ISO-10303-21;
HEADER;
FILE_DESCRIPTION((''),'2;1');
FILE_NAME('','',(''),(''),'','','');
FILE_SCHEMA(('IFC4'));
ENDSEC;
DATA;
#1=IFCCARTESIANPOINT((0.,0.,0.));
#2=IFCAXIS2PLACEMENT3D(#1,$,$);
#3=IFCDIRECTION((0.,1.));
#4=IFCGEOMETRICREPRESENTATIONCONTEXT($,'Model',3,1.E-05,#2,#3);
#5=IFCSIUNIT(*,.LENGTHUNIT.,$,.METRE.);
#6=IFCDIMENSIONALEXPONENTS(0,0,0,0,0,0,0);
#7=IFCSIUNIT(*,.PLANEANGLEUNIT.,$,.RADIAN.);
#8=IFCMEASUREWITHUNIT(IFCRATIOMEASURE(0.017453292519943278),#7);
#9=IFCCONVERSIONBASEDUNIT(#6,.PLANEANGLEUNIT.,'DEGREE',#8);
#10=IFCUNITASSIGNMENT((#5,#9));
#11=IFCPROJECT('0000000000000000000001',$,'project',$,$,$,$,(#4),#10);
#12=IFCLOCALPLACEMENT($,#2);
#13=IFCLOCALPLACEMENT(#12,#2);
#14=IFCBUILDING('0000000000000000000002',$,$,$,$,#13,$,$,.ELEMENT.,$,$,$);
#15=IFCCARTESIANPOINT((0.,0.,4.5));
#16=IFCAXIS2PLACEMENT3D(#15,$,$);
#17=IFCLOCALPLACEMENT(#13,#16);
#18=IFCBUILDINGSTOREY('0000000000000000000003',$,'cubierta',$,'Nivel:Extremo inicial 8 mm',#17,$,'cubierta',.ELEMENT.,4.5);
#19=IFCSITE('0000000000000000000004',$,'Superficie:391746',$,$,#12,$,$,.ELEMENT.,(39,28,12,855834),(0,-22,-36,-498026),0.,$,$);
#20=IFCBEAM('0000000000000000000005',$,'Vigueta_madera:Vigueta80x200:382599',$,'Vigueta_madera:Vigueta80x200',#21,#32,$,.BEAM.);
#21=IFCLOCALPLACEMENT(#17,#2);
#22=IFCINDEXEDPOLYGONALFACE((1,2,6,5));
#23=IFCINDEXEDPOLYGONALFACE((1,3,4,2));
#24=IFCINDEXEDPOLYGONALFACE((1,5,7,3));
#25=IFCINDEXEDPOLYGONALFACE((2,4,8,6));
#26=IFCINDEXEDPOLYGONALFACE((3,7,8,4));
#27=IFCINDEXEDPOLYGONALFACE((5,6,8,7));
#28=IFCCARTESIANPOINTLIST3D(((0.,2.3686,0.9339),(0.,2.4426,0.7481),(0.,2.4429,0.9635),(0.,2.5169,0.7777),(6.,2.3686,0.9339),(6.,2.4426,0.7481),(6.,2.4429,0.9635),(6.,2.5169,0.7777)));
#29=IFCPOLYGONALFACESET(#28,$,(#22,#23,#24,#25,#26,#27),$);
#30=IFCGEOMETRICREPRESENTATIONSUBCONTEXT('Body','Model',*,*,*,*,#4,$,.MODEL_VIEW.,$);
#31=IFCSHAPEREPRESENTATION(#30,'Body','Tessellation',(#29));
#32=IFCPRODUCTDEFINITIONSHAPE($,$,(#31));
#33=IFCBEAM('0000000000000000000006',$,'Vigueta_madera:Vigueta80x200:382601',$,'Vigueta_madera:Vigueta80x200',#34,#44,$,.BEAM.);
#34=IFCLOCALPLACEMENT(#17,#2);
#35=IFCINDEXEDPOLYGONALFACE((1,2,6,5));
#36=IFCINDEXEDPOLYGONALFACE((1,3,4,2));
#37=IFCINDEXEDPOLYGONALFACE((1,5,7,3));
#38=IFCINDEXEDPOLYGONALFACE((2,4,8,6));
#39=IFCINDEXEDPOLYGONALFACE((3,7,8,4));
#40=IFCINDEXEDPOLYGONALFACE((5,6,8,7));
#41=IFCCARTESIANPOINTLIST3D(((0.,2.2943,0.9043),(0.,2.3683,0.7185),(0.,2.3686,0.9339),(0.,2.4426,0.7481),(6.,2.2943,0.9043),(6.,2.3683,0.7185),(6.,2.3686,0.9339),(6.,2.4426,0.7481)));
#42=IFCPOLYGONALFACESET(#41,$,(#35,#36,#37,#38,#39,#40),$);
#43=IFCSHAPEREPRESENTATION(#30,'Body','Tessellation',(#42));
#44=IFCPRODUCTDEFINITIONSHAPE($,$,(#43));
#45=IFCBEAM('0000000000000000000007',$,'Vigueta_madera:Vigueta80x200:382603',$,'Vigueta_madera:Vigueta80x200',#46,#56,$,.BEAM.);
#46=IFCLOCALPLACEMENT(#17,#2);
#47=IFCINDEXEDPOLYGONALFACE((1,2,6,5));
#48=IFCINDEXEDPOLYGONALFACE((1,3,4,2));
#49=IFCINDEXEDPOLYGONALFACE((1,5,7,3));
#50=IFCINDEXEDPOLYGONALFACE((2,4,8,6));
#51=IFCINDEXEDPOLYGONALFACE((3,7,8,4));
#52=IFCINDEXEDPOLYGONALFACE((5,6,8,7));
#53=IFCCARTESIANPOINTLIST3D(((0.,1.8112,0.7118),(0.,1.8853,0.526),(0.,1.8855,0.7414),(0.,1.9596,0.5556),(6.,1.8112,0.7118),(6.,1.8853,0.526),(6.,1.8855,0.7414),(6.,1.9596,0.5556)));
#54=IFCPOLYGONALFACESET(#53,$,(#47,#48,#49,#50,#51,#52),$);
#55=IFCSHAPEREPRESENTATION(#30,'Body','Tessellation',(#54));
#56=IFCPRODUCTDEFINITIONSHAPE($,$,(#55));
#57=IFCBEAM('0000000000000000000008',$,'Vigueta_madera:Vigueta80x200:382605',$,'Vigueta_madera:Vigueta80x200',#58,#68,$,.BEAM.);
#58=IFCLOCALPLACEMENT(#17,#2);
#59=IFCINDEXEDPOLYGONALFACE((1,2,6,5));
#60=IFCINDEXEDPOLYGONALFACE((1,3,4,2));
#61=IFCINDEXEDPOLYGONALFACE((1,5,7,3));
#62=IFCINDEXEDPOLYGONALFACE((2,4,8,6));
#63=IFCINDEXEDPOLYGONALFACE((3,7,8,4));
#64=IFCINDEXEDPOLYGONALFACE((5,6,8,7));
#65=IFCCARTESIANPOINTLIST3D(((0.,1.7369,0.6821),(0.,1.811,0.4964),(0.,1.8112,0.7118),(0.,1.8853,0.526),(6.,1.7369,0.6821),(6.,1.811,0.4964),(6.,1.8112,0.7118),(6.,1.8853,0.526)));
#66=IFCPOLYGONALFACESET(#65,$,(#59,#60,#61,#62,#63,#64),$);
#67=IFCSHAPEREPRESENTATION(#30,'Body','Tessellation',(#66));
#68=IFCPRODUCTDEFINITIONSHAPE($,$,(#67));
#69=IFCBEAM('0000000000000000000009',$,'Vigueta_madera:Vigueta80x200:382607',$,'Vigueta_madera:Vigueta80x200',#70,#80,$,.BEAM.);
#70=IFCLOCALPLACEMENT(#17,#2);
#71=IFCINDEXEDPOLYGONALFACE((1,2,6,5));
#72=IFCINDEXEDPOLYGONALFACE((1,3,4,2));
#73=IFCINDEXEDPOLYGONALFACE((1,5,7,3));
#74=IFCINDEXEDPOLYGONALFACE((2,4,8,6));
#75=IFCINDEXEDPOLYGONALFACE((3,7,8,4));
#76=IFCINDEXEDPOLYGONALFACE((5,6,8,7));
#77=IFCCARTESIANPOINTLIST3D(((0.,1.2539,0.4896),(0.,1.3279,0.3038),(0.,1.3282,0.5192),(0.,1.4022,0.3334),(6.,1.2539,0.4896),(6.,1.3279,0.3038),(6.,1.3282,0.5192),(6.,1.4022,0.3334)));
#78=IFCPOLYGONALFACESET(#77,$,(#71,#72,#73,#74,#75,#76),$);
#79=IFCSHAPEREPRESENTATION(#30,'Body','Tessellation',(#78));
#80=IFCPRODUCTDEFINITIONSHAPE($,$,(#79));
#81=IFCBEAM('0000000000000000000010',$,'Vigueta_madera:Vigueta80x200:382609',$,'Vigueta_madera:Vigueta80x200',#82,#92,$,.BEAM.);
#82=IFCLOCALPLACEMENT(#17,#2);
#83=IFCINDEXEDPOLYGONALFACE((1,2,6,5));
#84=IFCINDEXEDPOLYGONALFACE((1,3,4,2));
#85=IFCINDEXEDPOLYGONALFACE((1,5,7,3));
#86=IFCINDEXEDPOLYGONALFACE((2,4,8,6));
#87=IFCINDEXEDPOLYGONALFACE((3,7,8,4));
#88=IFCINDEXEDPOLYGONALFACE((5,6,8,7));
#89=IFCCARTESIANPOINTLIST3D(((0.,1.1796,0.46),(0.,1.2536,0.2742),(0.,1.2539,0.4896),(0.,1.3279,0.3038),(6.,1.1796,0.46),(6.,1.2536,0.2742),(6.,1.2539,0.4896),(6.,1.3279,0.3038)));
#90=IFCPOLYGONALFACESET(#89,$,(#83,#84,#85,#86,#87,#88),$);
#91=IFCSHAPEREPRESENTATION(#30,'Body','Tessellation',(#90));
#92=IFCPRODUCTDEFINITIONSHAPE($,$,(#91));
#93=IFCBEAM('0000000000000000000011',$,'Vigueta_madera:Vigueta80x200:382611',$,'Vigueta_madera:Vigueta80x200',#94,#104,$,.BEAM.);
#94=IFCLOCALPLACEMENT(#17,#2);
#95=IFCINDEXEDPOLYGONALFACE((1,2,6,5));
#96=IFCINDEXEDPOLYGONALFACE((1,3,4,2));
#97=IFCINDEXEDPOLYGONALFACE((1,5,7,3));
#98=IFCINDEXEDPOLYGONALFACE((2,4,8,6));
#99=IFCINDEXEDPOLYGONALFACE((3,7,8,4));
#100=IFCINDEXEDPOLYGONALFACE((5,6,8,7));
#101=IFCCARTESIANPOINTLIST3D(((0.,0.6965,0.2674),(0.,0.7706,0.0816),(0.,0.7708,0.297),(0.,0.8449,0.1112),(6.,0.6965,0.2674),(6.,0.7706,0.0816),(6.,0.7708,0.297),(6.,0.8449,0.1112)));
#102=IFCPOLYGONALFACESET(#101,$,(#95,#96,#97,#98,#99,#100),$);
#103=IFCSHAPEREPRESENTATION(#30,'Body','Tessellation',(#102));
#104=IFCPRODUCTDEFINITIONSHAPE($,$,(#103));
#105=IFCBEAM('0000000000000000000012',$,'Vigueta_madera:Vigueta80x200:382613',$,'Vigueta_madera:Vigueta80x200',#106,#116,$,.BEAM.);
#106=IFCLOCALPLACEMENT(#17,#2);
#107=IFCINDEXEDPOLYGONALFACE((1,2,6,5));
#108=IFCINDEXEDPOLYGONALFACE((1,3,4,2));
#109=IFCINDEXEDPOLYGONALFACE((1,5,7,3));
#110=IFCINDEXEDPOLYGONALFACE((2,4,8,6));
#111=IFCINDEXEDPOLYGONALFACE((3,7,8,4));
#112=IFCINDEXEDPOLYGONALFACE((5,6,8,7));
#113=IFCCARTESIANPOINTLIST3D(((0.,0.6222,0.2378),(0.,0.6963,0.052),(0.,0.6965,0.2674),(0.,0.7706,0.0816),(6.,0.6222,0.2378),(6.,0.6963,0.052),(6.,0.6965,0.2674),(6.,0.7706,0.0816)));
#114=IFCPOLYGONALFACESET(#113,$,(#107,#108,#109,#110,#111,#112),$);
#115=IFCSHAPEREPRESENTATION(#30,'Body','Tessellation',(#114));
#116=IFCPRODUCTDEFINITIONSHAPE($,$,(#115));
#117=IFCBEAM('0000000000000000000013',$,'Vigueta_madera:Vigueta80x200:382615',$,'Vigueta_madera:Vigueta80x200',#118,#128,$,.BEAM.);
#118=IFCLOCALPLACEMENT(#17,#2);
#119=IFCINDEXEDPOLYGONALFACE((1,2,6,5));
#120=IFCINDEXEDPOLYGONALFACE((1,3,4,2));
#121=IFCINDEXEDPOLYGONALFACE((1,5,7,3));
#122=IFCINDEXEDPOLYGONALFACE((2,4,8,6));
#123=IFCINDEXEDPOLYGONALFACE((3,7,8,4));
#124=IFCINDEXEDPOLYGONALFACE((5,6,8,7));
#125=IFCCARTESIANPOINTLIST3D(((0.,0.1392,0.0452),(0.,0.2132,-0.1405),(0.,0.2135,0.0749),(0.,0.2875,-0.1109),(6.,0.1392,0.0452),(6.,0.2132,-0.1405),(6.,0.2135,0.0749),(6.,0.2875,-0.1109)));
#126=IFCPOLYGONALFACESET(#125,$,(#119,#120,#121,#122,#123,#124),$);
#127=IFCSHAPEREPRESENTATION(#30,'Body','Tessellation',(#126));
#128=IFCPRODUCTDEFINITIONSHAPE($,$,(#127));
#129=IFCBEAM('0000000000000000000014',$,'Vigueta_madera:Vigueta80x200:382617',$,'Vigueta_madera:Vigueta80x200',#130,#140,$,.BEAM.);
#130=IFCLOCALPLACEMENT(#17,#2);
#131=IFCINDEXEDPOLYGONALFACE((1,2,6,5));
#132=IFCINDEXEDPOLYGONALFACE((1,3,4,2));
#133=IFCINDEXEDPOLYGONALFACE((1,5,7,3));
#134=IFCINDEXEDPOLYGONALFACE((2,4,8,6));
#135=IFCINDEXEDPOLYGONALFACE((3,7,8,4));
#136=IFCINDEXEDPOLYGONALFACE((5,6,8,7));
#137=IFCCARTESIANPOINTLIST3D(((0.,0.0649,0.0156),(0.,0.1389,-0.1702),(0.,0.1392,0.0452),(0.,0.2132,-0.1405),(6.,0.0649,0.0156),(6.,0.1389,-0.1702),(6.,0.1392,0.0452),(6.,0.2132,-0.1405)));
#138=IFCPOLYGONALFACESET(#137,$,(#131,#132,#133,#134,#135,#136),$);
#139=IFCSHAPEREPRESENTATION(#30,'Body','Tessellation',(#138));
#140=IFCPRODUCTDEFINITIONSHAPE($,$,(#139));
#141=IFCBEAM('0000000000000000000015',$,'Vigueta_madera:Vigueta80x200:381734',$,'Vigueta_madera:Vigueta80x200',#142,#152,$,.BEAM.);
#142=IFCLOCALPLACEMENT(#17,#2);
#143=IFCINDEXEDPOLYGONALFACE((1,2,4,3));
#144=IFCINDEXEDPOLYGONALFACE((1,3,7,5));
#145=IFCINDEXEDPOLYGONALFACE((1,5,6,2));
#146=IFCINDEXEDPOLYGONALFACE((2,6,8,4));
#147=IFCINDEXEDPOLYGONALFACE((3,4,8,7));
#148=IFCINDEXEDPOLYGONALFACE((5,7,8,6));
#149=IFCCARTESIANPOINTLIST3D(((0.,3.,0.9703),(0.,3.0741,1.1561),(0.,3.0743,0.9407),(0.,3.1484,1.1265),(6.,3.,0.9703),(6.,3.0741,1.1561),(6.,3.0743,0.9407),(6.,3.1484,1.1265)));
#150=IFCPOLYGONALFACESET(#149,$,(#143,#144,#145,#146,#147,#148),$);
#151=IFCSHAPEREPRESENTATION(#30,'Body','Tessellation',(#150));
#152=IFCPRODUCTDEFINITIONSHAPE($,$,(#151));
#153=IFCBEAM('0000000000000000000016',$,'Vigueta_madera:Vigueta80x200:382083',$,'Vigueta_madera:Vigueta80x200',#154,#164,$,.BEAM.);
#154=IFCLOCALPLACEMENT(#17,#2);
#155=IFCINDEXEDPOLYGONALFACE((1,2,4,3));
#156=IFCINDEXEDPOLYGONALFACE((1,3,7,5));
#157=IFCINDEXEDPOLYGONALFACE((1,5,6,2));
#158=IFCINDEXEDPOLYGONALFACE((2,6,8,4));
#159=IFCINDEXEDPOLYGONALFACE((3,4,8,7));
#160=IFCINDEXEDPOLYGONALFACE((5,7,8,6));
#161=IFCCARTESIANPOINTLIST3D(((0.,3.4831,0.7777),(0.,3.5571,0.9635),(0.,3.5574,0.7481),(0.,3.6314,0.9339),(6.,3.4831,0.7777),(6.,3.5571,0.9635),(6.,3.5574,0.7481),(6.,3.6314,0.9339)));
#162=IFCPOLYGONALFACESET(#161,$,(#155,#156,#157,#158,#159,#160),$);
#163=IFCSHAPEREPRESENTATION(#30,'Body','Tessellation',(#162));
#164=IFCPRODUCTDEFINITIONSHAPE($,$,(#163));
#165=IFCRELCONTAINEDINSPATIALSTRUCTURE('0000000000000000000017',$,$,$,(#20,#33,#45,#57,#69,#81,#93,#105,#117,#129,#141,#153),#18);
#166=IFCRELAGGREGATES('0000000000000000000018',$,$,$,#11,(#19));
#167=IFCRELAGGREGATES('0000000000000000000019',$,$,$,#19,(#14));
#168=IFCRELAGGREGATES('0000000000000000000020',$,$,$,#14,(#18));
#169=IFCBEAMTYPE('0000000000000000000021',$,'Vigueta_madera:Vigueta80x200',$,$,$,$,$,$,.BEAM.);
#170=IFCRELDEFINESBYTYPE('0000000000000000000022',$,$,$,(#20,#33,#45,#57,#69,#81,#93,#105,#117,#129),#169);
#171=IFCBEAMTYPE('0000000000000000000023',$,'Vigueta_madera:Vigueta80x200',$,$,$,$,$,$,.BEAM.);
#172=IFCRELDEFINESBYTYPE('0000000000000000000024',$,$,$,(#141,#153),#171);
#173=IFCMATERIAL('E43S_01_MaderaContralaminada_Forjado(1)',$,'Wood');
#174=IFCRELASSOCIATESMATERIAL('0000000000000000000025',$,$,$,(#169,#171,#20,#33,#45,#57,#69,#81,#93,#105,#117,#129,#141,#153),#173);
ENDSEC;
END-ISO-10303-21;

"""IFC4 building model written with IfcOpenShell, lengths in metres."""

from ifc_helpers import new_model, entity, si_unit, converted_unit, direction, frame, frame_2d, origin, place, context, subcontext, project, spatial, polyline, segment, composite_curve, rectangle, outline, extrude, source, transform, mapped, material, material_profile, profile_set, profile_usage, type_object, type_shapes, element, save


model = new_model("IFC4")

# Units and contexts
model_context = context("Model", 3, precision=1e-05, world=origin(), true_north=direction((0.0, 1.0)))
body_context = subcontext(model_context, "Body", "Model", "MODEL_VIEW")
ifc_project = project(units=[si_unit("LENGTHUNIT", "METRE"), converted_unit("PLANEANGLEUNIT", "DEGREE", entity("IfcRatioMeasure", 0.017453292519943278), si_unit("PLANEANGLEUNIT", "RADIAN"), dimensions=[0, 0, 0, 0, 0, 0, 0])], contexts=[model_context])

# Site, building, storey
site_placement = place(None, origin())
site = spatial("IfcSite", under=ifc_project, at=site_placement, Name="Superficie:391746", CompositionType="ELEMENT", RefLatitude=(39, 28, 12, 855834), RefLongitude=(0, -22, -36, -498026), RefElevation=0.0)
building_placement = place(site_placement, origin())
building = spatial("IfcBuilding", under=site, at=building_placement, CompositionType="ELEMENT")
storey_placement = place(building_placement, frame((0.0, 0.0, 4.5)))
storey = spatial("IfcBuildingStorey", under=building, at=storey_placement, Name="cubierta", ObjectType="Nivel:Extremo inicial 8 mm", LongName="cubierta", CompositionType="ELEMENT", Elevation=4.5)

# Beams
ifc_material = material(Name="E43S_01_MaderaContralaminada_Forjado(1)", Category="Wood")
ifc_material_profile_1 = material_profile(ifc_material, outline(composite_curve([segment(polyline([(0.04, 0.1, 0.0), (0.04, -0.1, 0.0)]), True, "CONTINUOUS"), segment(polyline([(0.04, -0.1, 0.0), (-0.04, -0.1, 0.0)]), True, "CONTINUOUS"), segment(polyline([(-0.04, -0.1, 0.0), (-0.04, 0.1, 0.0)]), True, "CONTINUOUS"), segment(polyline([(-0.04, 0.1, 0.0), (0.04, 0.1, 0.0)]), True, "CONTINUOUS")], self_intersect=False), kind="CURVE"), Name="Vigueta80x200")
ifc_material_profile_2 = material_profile(ifc_material, outline(composite_curve([segment(polyline([(-3.0, 0.04, 0.1), (-3.0, 0.04, -0.1)]), True, "CONTINUOUS"), segment(polyline([(-3.0, 0.04, -0.1), (-3.0, -0.04, -0.1)]), True, "CONTINUOUS"), segment(polyline([(-3.0, -0.04, -0.1), (-3.0, -0.04, 0.1)]), True, "CONTINUOUS"), segment(polyline([(-3.0, -0.04, 0.1), (-3.0, 0.04, 0.1)]), True, "CONTINUOUS")], self_intersect=False), kind="CURVE"), Name="Vigueta80x200")
ifc_profile_set = profile_set([ifc_material_profile_1, ifc_material_profile_2], Name="Vigueta80x200")
ifc_profile_usage_1 = profile_usage(ifc_profile_set, cardinal=8)
beam_type_1 = type_object("IfcBeamType", Name="Vigueta_madera:Vigueta80x200", PredefinedType="BEAM", material=ifc_profile_set)
shared_shape_1 = source(origin(), body_context, "Body", "SweptSolid", [
    extrude(rectangle(XDim=0.2, YDim=0.08, at=frame_2d((0.0, 0.0), x_axis=(1.0, 0.0))), frame((-3.0, 0.0, 0.0), z_axis=(1.0, 0.0, 0.0), x_axis=(0.0, 0.0, -1.0)), (0.0, 0.0, 1.0), 6.0),
])
type_shapes(beam_type_1, [shared_shape_1])
beam_1_placement = place(storey_placement, frame((3.0, 2.4428, 0.8558), z_axis=(0.0, -0.370233, 0.928939), x_axis=(1.0, 0.0, 0.0)))
element("IfcBeam", 1, at=beam_1_placement, inside=storey, type_object=beam_type_1, material=ifc_profile_usage_1, Name="Vigueta_madera:Vigueta80x200:382599", ObjectType="Vigueta_madera:Vigueta80x200", PredefinedType="BEAM", context=body_context, shape_type="MappedRepresentation", body=[
    mapped(shared_shape_1, transform((0.0, 0.0, 0.0), scale=1.0)),
])
ifc_profile_usage_2 = profile_usage(ifc_profile_set, cardinal=8)
beam_2_placement = place(storey_placement, frame((3.0, 2.3685, 0.8262), z_axis=(0.0, -0.370233, 0.928939), x_axis=(1.0, 0.0, 0.0)))
element("IfcBeam", 2, at=beam_2_placement, inside=storey, type_object=beam_type_1, material=ifc_profile_usage_2, Name="Vigueta_madera:Vigueta80x200:382601", ObjectType="Vigueta_madera:Vigueta80x200", PredefinedType="BEAM", context=body_context, shape_type="MappedRepresentation", body=[
    mapped(shared_shape_1, transform((0.0, 0.0, 0.0), scale=1.0)),
])
ifc_profile_usage_3 = profile_usage(ifc_profile_set, cardinal=8)
beam_3_placement = place(storey_placement, frame((3.0, 1.8854, 0.6337), z_axis=(0.0, -0.370233, 0.928939), x_axis=(1.0, 0.0, 0.0)))
element("IfcBeam", 3, at=beam_3_placement, inside=storey, type_object=beam_type_1, material=ifc_profile_usage_3, Name="Vigueta_madera:Vigueta80x200:382603", ObjectType="Vigueta_madera:Vigueta80x200", PredefinedType="BEAM", context=body_context, shape_type="MappedRepresentation", body=[
    mapped(shared_shape_1, transform((0.0, 0.0, 0.0), scale=1.0)),
])
ifc_profile_usage_4 = profile_usage(ifc_profile_set, cardinal=8)
beam_4_placement = place(storey_placement, frame((3.0, 1.8111, 0.6041), z_axis=(0.0, -0.370233, 0.928939), x_axis=(1.0, 0.0, 0.0)))
element("IfcBeam", 4, at=beam_4_placement, inside=storey, type_object=beam_type_1, material=ifc_profile_usage_4, Name="Vigueta_madera:Vigueta80x200:382605", ObjectType="Vigueta_madera:Vigueta80x200", PredefinedType="BEAM", context=body_context, shape_type="MappedRepresentation", body=[
    mapped(shared_shape_1, transform((0.0, 0.0, 0.0), scale=1.0)),
])
ifc_profile_usage_5 = profile_usage(ifc_profile_set, cardinal=8)
beam_5_placement = place(storey_placement, frame((3.0, 1.3281, 0.4115), z_axis=(0.0, -0.370233, 0.928939), x_axis=(1.0, 0.0, 0.0)))
element("IfcBeam", 5, at=beam_5_placement, inside=storey, type_object=beam_type_1, material=ifc_profile_usage_5, Name="Vigueta_madera:Vigueta80x200:382607", ObjectType="Vigueta_madera:Vigueta80x200", PredefinedType="BEAM", context=body_context, shape_type="MappedRepresentation", body=[
    mapped(shared_shape_1, transform((0.0, 0.0, 0.0), scale=1.0)),
])
ifc_profile_usage_6 = profile_usage(ifc_profile_set, cardinal=8)
beam_6_placement = place(storey_placement, frame((3.0, 1.2537, 0.3819), z_axis=(0.0, -0.370233, 0.928939), x_axis=(1.0, 0.0, 0.0)))
element("IfcBeam", 6, at=beam_6_placement, inside=storey, type_object=beam_type_1, material=ifc_profile_usage_6, Name="Vigueta_madera:Vigueta80x200:382609", ObjectType="Vigueta_madera:Vigueta80x200", PredefinedType="BEAM", context=body_context, shape_type="MappedRepresentation", body=[
    mapped(shared_shape_1, transform((0.0, 0.0, 0.0), scale=1.0)),
])
ifc_profile_usage_7 = profile_usage(ifc_profile_set, cardinal=8)
beam_7_placement = place(storey_placement, frame((3.0, 0.7707, 0.1893), z_axis=(0.0, -0.370233, 0.928939), x_axis=(1.0, 0.0, 0.0)))
element("IfcBeam", 7, at=beam_7_placement, inside=storey, type_object=beam_type_1, material=ifc_profile_usage_7, Name="Vigueta_madera:Vigueta80x200:382611", ObjectType="Vigueta_madera:Vigueta80x200", PredefinedType="BEAM", context=body_context, shape_type="MappedRepresentation", body=[
    mapped(shared_shape_1, transform((0.0, 0.0, 0.0), scale=1.0)),
])
ifc_profile_usage_8 = profile_usage(ifc_profile_set, cardinal=8)
beam_8_placement = place(storey_placement, frame((3.0, 0.6964, 0.1597), z_axis=(0.0, -0.370233, 0.928939), x_axis=(1.0, 0.0, 0.0)))
element("IfcBeam", 8, at=beam_8_placement, inside=storey, type_object=beam_type_1, material=ifc_profile_usage_8, Name="Vigueta_madera:Vigueta80x200:382613", ObjectType="Vigueta_madera:Vigueta80x200", PredefinedType="BEAM", context=body_context, shape_type="MappedRepresentation", body=[
    mapped(shared_shape_1, transform((0.0, 0.0, 0.0), scale=1.0)),
])
ifc_profile_usage_9 = profile_usage(ifc_profile_set, cardinal=8)
beam_9_placement = place(storey_placement, frame((3.0, 0.2134, -0.0328), z_axis=(0.0, -0.370233, 0.928939), x_axis=(1.0, 0.0, 0.0)))
element("IfcBeam", 9, at=beam_9_placement, inside=storey, type_object=beam_type_1, material=ifc_profile_usage_9, Name="Vigueta_madera:Vigueta80x200:382615", ObjectType="Vigueta_madera:Vigueta80x200", PredefinedType="BEAM", context=body_context, shape_type="MappedRepresentation", body=[
    mapped(shared_shape_1, transform((0.0, 0.0, 0.0), scale=1.0)),
])
ifc_profile_usage_10 = profile_usage(ifc_profile_set, cardinal=8)
beam_10_placement = place(storey_placement, frame((3.0, 0.139, -0.0625), z_axis=(0.0, -0.370233, 0.928939), x_axis=(1.0, 0.0, 0.0)))
element("IfcBeam", 10, at=beam_10_placement, inside=storey, type_object=beam_type_1, material=ifc_profile_usage_10, Name="Vigueta_madera:Vigueta80x200:382617", ObjectType="Vigueta_madera:Vigueta80x200", PredefinedType="BEAM", context=body_context, shape_type="MappedRepresentation", body=[
    mapped(shared_shape_1, transform((0.0, 0.0, 0.0), scale=1.0)),
])
ifc_profile_usage_11 = profile_usage(ifc_profile_set, cardinal=8)
beam_type_2 = type_object("IfcBeamType", Name="Vigueta_madera:Vigueta80x200", PredefinedType="BEAM", material=ifc_profile_set)
shared_shape_2 = source(origin(), body_context, "Body", "SweptSolid", [
    extrude(rectangle(XDim=0.2, YDim=0.08, at=frame_2d((0.0, 0.0), x_axis=(1.0, 0.0))), frame((-3.0, 0.0, 0.0), z_axis=(1.0, 0.0, 0.0), x_axis=(0.0, 0.0, -1.0)), (0.0, 0.0, 1.0), 6.0),
])
type_shapes(beam_type_2, [shared_shape_2])
beam_11_placement = place(storey_placement, frame((3.0, 3.0742, 1.0484), z_axis=(0.0, 0.370233, 0.928939), x_axis=(1.0, 0.0, 0.0)))
element("IfcBeam", 11, at=beam_11_placement, inside=storey, type_object=beam_type_2, material=ifc_profile_usage_11, Name="Vigueta_madera:Vigueta80x200:381734", ObjectType="Vigueta_madera:Vigueta80x200", PredefinedType="BEAM", context=body_context, shape_type="MappedRepresentation", body=[
    mapped(shared_shape_2, transform((0.0, 0.0, 0.0), scale=1.0)),
])
ifc_profile_usage_12 = profile_usage(ifc_profile_set, cardinal=8)
beam_12_placement = place(storey_placement, frame((3.0, 3.5572, 0.8558), z_axis=(0.0, 0.370233, 0.928939), x_axis=(1.0, 0.0, 0.0)))
element("IfcBeam", 12, at=beam_12_placement, inside=storey, type_object=beam_type_2, material=ifc_profile_usage_12, Name="Vigueta_madera:Vigueta80x200:382083", ObjectType="Vigueta_madera:Vigueta80x200", PredefinedType="BEAM", context=body_context, shape_type="MappedRepresentation", body=[
    mapped(shared_shape_2, transform((0.0, 0.0, 0.0), scale=1.0)),
])

save(model, "model.ifc")
